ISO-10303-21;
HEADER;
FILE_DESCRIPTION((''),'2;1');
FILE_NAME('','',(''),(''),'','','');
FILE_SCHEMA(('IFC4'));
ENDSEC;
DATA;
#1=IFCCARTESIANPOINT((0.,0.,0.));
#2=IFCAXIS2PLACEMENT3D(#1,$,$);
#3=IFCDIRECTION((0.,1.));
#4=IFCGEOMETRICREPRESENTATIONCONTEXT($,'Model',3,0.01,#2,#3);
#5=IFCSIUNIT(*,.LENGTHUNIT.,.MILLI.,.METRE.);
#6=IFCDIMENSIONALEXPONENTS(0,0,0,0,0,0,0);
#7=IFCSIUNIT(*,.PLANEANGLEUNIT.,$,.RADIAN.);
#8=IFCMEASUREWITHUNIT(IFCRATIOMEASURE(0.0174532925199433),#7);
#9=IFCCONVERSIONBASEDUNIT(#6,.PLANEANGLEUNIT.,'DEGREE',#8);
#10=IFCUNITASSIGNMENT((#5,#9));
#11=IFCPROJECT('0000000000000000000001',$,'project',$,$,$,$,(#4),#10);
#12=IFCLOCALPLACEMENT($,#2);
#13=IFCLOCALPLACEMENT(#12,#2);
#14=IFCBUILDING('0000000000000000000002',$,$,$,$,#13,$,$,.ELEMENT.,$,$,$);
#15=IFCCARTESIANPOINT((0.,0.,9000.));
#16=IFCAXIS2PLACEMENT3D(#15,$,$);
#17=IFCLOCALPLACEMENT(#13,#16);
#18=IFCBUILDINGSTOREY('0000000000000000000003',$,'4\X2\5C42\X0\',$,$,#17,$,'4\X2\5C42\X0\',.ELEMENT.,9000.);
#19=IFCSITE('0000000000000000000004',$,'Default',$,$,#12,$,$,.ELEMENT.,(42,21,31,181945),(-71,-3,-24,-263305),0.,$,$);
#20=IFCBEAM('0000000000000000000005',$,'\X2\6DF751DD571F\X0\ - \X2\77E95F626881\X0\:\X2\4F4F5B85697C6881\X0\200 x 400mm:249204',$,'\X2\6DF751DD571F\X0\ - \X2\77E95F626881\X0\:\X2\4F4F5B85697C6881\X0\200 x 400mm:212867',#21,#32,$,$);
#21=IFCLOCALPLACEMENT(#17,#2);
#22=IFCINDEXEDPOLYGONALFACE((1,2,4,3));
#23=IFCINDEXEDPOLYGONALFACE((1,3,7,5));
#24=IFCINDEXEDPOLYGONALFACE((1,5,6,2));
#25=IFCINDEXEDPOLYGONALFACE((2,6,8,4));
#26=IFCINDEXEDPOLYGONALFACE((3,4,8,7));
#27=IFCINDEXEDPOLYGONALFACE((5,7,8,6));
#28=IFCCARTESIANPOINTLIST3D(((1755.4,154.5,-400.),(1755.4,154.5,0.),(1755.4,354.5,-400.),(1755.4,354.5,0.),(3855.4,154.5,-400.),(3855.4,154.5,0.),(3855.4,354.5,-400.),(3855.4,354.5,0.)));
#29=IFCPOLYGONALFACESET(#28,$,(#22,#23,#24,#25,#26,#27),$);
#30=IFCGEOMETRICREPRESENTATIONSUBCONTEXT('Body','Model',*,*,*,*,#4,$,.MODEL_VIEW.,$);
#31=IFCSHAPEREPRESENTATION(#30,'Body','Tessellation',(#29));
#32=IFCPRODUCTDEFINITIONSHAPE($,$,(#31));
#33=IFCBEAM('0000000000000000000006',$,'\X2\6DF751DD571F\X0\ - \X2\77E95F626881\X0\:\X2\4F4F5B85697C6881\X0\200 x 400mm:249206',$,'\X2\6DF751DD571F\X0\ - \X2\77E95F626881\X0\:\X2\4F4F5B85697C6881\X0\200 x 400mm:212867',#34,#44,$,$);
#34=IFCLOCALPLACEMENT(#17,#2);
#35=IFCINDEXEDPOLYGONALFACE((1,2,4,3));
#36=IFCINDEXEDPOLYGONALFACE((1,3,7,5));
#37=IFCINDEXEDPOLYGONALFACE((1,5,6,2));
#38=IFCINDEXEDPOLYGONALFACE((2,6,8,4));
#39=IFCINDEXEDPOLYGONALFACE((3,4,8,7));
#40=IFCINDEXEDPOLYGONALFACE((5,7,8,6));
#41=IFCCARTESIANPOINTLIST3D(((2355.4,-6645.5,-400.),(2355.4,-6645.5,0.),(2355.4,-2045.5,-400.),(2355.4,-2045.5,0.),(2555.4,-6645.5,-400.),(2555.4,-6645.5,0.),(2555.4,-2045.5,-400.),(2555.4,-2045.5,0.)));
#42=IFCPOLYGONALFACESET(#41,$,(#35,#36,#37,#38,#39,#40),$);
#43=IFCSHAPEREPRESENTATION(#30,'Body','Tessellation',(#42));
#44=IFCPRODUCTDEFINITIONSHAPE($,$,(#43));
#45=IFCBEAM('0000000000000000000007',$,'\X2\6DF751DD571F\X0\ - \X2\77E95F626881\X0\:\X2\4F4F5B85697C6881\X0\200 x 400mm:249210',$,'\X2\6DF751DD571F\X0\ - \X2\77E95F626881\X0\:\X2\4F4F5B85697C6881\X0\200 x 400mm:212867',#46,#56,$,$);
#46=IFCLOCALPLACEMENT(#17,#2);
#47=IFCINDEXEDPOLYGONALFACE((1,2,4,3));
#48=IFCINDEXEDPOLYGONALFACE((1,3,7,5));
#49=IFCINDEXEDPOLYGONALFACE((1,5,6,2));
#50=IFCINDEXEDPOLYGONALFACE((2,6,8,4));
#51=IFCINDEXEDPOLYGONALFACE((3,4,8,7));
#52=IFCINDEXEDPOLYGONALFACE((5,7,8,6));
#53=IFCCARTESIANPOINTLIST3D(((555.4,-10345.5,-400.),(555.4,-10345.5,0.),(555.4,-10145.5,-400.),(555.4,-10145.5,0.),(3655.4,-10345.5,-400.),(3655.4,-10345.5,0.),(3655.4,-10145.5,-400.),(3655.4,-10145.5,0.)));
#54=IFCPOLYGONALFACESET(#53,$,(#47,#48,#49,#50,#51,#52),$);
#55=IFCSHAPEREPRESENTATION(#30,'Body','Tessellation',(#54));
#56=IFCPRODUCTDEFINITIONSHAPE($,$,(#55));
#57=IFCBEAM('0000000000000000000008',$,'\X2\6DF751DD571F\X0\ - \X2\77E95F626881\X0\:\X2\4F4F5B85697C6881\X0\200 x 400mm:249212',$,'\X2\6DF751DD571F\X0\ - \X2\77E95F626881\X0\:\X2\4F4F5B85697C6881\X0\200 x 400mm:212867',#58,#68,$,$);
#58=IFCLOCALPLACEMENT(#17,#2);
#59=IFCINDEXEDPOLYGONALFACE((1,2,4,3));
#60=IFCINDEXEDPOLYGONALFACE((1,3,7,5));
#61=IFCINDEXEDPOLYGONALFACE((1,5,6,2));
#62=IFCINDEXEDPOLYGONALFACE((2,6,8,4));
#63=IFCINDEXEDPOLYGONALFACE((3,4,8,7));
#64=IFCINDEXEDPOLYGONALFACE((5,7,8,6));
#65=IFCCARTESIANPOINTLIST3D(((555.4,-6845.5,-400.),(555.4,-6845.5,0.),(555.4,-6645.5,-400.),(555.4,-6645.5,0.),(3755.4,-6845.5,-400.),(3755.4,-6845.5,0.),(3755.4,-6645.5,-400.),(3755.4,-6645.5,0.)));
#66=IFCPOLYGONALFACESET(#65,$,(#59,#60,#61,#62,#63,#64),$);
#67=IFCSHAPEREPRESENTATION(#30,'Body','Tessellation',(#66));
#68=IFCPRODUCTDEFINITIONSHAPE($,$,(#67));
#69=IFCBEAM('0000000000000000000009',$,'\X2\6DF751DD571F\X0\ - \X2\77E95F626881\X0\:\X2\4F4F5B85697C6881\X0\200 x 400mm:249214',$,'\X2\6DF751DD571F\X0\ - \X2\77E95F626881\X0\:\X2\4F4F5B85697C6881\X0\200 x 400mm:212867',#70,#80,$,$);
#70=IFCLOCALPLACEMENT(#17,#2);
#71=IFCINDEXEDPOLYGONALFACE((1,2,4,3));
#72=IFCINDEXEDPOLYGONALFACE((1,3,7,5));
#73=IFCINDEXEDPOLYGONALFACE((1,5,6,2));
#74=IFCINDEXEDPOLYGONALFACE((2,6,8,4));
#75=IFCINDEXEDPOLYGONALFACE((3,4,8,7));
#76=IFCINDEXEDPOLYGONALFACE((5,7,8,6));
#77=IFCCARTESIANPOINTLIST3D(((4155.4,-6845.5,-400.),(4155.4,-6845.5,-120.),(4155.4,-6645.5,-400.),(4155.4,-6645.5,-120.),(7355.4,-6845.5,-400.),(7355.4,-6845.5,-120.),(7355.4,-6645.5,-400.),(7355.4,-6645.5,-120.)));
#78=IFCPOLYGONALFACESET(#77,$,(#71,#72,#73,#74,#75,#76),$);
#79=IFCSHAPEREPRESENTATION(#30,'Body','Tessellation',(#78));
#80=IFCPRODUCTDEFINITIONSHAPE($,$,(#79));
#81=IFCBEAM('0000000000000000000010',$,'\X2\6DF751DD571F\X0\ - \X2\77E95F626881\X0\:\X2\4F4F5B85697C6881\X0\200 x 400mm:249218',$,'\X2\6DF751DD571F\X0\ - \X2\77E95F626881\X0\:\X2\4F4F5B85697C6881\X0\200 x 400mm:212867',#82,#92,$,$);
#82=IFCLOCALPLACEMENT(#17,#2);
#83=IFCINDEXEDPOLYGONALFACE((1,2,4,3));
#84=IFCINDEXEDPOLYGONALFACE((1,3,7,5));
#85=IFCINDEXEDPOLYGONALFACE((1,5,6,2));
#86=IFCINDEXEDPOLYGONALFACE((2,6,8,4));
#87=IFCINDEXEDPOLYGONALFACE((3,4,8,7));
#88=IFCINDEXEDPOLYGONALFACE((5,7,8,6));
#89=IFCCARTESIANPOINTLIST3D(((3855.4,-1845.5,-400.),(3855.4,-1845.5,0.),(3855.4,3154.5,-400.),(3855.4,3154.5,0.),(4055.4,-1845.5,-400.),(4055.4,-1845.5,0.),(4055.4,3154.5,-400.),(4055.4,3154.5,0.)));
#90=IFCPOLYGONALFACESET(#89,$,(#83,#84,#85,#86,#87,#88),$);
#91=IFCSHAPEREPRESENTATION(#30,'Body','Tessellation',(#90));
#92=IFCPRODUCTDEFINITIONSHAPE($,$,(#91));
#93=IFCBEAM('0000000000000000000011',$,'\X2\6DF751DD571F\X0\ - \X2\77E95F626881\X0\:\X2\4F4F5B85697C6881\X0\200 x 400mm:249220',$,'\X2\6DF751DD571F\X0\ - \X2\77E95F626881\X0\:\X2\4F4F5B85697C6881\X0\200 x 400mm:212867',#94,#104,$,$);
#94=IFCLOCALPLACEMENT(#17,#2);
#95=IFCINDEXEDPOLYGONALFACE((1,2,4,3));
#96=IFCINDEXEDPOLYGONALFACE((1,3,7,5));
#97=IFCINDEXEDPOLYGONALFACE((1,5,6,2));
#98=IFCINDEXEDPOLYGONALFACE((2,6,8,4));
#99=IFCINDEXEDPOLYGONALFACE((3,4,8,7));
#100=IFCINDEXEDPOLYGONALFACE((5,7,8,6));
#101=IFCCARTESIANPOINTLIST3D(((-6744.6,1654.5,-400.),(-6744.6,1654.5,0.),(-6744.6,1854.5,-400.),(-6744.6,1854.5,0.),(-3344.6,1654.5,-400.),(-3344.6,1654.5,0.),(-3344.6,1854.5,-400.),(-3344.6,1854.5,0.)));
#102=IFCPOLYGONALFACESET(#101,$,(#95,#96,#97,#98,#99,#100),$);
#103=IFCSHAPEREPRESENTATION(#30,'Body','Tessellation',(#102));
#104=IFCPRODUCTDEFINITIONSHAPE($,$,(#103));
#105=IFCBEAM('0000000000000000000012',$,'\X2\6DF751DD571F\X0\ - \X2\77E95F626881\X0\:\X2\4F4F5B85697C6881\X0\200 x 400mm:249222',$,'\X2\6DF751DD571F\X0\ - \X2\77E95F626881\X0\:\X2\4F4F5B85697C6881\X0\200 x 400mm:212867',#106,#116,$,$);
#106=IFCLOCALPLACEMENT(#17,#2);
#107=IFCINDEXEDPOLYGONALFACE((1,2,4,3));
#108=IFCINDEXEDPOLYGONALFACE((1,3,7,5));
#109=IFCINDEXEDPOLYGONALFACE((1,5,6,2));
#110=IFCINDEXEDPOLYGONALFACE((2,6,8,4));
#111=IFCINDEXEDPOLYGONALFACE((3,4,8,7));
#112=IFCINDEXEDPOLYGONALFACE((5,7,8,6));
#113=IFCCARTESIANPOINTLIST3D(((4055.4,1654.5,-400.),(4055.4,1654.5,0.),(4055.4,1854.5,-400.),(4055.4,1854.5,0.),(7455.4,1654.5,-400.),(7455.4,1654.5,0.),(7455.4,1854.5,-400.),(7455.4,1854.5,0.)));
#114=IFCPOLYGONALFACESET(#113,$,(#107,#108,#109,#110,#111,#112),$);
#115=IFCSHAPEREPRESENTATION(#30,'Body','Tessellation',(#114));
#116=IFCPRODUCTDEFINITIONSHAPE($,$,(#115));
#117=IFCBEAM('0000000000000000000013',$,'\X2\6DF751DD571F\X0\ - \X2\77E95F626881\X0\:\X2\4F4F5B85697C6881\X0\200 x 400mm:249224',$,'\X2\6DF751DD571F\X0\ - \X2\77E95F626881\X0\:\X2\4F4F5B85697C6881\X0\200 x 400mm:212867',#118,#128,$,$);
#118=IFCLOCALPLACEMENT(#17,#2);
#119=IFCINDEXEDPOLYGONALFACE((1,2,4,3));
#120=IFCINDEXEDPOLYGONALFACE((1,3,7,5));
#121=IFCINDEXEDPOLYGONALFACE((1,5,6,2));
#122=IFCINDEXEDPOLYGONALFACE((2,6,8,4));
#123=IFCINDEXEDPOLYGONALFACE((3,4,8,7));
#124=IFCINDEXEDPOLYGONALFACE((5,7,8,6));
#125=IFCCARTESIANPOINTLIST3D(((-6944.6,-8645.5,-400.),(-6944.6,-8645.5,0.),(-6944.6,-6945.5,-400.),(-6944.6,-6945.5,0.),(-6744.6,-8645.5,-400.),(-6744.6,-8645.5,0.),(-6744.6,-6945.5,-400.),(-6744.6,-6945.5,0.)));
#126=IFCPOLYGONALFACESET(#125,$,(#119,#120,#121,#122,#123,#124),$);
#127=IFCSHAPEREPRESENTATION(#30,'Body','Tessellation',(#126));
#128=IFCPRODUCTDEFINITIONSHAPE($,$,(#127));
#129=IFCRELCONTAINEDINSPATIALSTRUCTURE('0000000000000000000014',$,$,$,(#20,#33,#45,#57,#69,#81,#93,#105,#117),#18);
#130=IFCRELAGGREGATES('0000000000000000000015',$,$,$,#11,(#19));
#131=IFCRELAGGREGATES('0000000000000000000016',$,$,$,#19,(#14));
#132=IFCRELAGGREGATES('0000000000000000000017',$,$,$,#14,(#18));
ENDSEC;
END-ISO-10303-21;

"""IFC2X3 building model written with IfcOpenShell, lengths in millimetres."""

from ifc_helpers import new_model, entity, si_unit, converted_unit, direction, frame, frame_2d, origin, origin_2d_with_axis, place, context, subcontext, project, spatial, rectangle, extrude, element, save


model = new_model("IFC2X3")

# Units and contexts
model_context = context("Model", 3, precision=0.01, world=origin(), true_north=direction((0.0, 1.0)))
body_context = subcontext(model_context, "Body", "Model", "MODEL_VIEW")
ifc_project = project(units=[si_unit("LENGTHUNIT", "METRE", prefix="MILLI"), converted_unit("PLANEANGLEUNIT", "DEGREE", entity("IfcRatioMeasure", 0.0174532925199433), si_unit("PLANEANGLEUNIT", "RADIAN"), dimensions=[0, 0, 0, 0, 0, 0, 0])], contexts=[model_context])

# Site, building, storey
site_placement = place(None, origin())
site = spatial("IfcSite", under=ifc_project, at=site_placement, Name="Default", CompositionType="ELEMENT", RefLatitude=(42, 21, 31, 181945), RefLongitude=(-71, -3, -24, -263305), RefElevation=0.0)
building_placement = place(site_placement, origin())
building = spatial("IfcBuilding", under=site, at=building_placement, CompositionType="ELEMENT")
storey_placement = place(building_placement, frame((0.0, 0.0, 9000.0)))
storey = spatial("IfcBuildingStorey", under=building, at=storey_placement, Name="4层", LongName="4层", CompositionType="ELEMENT", Elevation=9000.0)

# Beams
beam_1_placement = place(storey_placement, frame((3955.4, 254.5, 0.0), z_axis=(0.0, 0.0, 1.0), x_axis=(-1.0, 0.0, 0.0)))
element("IfcBeam", 1, at=beam_1_placement, inside=storey, Name="混凝土 - 矩形梁:住宅楼梁200 x 400mm:249204", ObjectType="混凝土 - 矩形梁:住宅楼梁200 x 400mm:212867", context=body_context, shape_type="SweptSolid", body=[
    extrude(rectangle(XDim=400.0, YDim=200.0, at=frame_2d((0.0, 0.0), x_axis=(1.0, 0.0))), frame((100.0, 0.0, -200.0), z_axis=(1.0, 0.0, 0.0), x_axis=(0.0, 0.0, -1.0)), (0.0, 0.0, 1.0), 2100.0),
])
beam_2_placement = place(storey_placement, frame((2455.4, -1945.5, 0.0), z_axis=(0.0, 0.0, 1.0), x_axis=(0.0, -1.0, 0.0)))
element("IfcBeam", 2, at=beam_2_placement, inside=storey, Name="混凝土 - 矩形梁:住宅楼梁200 x 400mm:249206", ObjectType="混凝土 - 矩形梁:住宅楼梁200 x 400mm:212867", context=body_context, shape_type="SweptSolid", body=[
    extrude(rectangle(XDim=400.0, YDim=200.0, at=origin_2d_with_axis()), frame((100.0, 0.0, -200.0), z_axis=(1.0, 0.0, 0.0), x_axis=(0.0, 0.0, -1.0)), (0.0, 0.0, 1.0), 4600.0),
])
beam_3_placement = place(storey_placement, frame((3655.4, -10245.5, 0.0), z_axis=(0.0, 0.0, 1.0), x_axis=(-1.0, 0.0, 0.0)))
element("IfcBeam", 3, at=beam_3_placement, inside=storey, Name="混凝土 - 矩形梁:住宅楼梁200 x 400mm:249210", ObjectType="混凝土 - 矩形梁:住宅楼梁200 x 400mm:212867", context=body_context, shape_type="SweptSolid", body=[
    extrude(rectangle(XDim=400.0, YDim=200.0, at=frame_2d((0.0, 0.0), x_axis=(1.0, 0.0))), frame((0.0, 0.0, -200.0), z_axis=(1.0, 0.0, 0.0), x_axis=(0.0, 0.0, -1.0)), (0.0, 0.0, 1.0), 3100.0),
])
beam_4_placement = place(storey_placement, frame((3955.4, -6745.5, 0.0), z_axis=(0.0, 0.0, 1.0), x_axis=(-1.0, 0.0, 0.0)))
element("IfcBeam", 4, at=beam_4_placement, inside=storey, Name="混凝土 - 矩形梁:住宅楼梁200 x 400mm:249212", ObjectType="混凝土 - 矩形梁:住宅楼梁200 x 400mm:212867", context=body_context, shape_type="SweptSolid", body=[
    extrude(rectangle(XDim=400.0, YDim=200.0, at=frame_2d((0.0, 0.0), x_axis=(1.0, 0.0))), frame((200.0, 0.0, -200.0), z_axis=(1.0, 0.0, 0.0), x_axis=(0.0, 0.0, -1.0)), (0.0, 0.0, 1.0), 3200.0),
])
beam_5_placement = place(storey_placement, frame((3955.4, -6745.5, 0.0)))
element("IfcBeam", 5, at=beam_5_placement, inside=storey, Name="混凝土 - 矩形梁:住宅楼梁200 x 400mm:249214", ObjectType="混凝土 - 矩形梁:住宅楼梁200 x 400mm:212867", context=body_context, shape_type="SweptSolid", body=[
    extrude(rectangle(XDim=280.0, YDim=200.0, at=frame_2d((0.0, 0.0), x_axis=(1.0, 0.0))), frame((200.0, 0.0, -260.0), z_axis=(1.0, 0.0, 0.0), x_axis=(0.0, 0.0, -1.0)), (0.0, 0.0, 1.0), 3200.0),
])
beam_6_placement = place(storey_placement, frame((3955.4, 3254.5, 0.0), z_axis=(0.0, 0.0, 1.0), x_axis=(0.0, -1.0, 0.0)))
element("IfcBeam", 6, at=beam_6_placement, inside=storey, Name="混凝土 - 矩形梁:住宅楼梁200 x 400mm:249218", ObjectType="混凝土 - 矩形梁:住宅楼梁200 x 400mm:212867", context=body_context, shape_type="SweptSolid", body=[
    extrude(rectangle(XDim=400.0, YDim=200.0, at=frame_2d((0.0, 0.0), x_axis=(1.0, 0.0))), frame((100.0, 0.0, -200.0), z_axis=(1.0, 0.0, 0.0), x_axis=(0.0, 0.0, -1.0)), (0.0, 0.0, 1.0), 5000.0),
])
beam_7_placement = place(storey_placement, frame((-6844.6, 1754.5, 0.0)))
element("IfcBeam", 7, at=beam_7_placement, inside=storey, Name="混凝土 - 矩形梁:住宅楼梁200 x 400mm:249220", ObjectType="混凝土 - 矩形梁:住宅楼梁200 x 400mm:212867", context=body_context, shape_type="SweptSolid", body=[
    extrude(rectangle(XDim=400.0, YDim=200.0, at=frame_2d((0.0, 0.0), x_axis=(1.0, 0.0))), frame((100.0, 0.0, -200.0), z_axis=(1.0, 0.0, 0.0), x_axis=(0.0, 0.0, -1.0)), (0.0, 0.0, 1.0), 3400.0),
])
beam_8_placement = place(storey_placement, frame((7555.4, 1754.5, 0.0), z_axis=(0.0, 0.0, 1.0), x_axis=(-1.0, 0.0, 0.0)))
element("IfcBeam", 8, at=beam_8_placement, inside=storey, Name="混凝土 - 矩形梁:住宅楼梁200 x 400mm:249222", ObjectType="混凝土 - 矩形梁:住宅楼梁200 x 400mm:212867", context=body_context, shape_type="SweptSolid", body=[
    extrude(rectangle(XDim=400.0, YDim=200.0, at=frame_2d((0.0, 0.0), x_axis=(1.0, 0.0))), frame((100.0, 0.0, -200.0), z_axis=(1.0, 0.0, 0.0), x_axis=(0.0, 0.0, -1.0)), (0.0, 0.0, 1.0), 3400.0),
])
beam_9_placement = place(storey_placement, frame((-6844.6, -6745.5, 0.0), z_axis=(0.0, 0.0, 1.0), x_axis=(0.0, -1.0, 0.0)))
element("IfcBeam", 9, at=beam_9_placement, inside=storey, Name="混凝土 - 矩形梁:住宅楼梁200 x 400mm:249224", ObjectType="混凝土 - 矩形梁:住宅楼梁200 x 400mm:212867", context=body_context, shape_type="SweptSolid", body=[
    extrude(rectangle(XDim=400.0, YDim=200.0, at=origin_2d_with_axis()), frame((200.0, 0.0, -200.0), z_axis=(1.0, 0.0, 0.0), x_axis=(0.0, 0.0, -1.0)), (0.0, 0.0, 1.0), 1700.0),
])

save(model, "model.ifc")
